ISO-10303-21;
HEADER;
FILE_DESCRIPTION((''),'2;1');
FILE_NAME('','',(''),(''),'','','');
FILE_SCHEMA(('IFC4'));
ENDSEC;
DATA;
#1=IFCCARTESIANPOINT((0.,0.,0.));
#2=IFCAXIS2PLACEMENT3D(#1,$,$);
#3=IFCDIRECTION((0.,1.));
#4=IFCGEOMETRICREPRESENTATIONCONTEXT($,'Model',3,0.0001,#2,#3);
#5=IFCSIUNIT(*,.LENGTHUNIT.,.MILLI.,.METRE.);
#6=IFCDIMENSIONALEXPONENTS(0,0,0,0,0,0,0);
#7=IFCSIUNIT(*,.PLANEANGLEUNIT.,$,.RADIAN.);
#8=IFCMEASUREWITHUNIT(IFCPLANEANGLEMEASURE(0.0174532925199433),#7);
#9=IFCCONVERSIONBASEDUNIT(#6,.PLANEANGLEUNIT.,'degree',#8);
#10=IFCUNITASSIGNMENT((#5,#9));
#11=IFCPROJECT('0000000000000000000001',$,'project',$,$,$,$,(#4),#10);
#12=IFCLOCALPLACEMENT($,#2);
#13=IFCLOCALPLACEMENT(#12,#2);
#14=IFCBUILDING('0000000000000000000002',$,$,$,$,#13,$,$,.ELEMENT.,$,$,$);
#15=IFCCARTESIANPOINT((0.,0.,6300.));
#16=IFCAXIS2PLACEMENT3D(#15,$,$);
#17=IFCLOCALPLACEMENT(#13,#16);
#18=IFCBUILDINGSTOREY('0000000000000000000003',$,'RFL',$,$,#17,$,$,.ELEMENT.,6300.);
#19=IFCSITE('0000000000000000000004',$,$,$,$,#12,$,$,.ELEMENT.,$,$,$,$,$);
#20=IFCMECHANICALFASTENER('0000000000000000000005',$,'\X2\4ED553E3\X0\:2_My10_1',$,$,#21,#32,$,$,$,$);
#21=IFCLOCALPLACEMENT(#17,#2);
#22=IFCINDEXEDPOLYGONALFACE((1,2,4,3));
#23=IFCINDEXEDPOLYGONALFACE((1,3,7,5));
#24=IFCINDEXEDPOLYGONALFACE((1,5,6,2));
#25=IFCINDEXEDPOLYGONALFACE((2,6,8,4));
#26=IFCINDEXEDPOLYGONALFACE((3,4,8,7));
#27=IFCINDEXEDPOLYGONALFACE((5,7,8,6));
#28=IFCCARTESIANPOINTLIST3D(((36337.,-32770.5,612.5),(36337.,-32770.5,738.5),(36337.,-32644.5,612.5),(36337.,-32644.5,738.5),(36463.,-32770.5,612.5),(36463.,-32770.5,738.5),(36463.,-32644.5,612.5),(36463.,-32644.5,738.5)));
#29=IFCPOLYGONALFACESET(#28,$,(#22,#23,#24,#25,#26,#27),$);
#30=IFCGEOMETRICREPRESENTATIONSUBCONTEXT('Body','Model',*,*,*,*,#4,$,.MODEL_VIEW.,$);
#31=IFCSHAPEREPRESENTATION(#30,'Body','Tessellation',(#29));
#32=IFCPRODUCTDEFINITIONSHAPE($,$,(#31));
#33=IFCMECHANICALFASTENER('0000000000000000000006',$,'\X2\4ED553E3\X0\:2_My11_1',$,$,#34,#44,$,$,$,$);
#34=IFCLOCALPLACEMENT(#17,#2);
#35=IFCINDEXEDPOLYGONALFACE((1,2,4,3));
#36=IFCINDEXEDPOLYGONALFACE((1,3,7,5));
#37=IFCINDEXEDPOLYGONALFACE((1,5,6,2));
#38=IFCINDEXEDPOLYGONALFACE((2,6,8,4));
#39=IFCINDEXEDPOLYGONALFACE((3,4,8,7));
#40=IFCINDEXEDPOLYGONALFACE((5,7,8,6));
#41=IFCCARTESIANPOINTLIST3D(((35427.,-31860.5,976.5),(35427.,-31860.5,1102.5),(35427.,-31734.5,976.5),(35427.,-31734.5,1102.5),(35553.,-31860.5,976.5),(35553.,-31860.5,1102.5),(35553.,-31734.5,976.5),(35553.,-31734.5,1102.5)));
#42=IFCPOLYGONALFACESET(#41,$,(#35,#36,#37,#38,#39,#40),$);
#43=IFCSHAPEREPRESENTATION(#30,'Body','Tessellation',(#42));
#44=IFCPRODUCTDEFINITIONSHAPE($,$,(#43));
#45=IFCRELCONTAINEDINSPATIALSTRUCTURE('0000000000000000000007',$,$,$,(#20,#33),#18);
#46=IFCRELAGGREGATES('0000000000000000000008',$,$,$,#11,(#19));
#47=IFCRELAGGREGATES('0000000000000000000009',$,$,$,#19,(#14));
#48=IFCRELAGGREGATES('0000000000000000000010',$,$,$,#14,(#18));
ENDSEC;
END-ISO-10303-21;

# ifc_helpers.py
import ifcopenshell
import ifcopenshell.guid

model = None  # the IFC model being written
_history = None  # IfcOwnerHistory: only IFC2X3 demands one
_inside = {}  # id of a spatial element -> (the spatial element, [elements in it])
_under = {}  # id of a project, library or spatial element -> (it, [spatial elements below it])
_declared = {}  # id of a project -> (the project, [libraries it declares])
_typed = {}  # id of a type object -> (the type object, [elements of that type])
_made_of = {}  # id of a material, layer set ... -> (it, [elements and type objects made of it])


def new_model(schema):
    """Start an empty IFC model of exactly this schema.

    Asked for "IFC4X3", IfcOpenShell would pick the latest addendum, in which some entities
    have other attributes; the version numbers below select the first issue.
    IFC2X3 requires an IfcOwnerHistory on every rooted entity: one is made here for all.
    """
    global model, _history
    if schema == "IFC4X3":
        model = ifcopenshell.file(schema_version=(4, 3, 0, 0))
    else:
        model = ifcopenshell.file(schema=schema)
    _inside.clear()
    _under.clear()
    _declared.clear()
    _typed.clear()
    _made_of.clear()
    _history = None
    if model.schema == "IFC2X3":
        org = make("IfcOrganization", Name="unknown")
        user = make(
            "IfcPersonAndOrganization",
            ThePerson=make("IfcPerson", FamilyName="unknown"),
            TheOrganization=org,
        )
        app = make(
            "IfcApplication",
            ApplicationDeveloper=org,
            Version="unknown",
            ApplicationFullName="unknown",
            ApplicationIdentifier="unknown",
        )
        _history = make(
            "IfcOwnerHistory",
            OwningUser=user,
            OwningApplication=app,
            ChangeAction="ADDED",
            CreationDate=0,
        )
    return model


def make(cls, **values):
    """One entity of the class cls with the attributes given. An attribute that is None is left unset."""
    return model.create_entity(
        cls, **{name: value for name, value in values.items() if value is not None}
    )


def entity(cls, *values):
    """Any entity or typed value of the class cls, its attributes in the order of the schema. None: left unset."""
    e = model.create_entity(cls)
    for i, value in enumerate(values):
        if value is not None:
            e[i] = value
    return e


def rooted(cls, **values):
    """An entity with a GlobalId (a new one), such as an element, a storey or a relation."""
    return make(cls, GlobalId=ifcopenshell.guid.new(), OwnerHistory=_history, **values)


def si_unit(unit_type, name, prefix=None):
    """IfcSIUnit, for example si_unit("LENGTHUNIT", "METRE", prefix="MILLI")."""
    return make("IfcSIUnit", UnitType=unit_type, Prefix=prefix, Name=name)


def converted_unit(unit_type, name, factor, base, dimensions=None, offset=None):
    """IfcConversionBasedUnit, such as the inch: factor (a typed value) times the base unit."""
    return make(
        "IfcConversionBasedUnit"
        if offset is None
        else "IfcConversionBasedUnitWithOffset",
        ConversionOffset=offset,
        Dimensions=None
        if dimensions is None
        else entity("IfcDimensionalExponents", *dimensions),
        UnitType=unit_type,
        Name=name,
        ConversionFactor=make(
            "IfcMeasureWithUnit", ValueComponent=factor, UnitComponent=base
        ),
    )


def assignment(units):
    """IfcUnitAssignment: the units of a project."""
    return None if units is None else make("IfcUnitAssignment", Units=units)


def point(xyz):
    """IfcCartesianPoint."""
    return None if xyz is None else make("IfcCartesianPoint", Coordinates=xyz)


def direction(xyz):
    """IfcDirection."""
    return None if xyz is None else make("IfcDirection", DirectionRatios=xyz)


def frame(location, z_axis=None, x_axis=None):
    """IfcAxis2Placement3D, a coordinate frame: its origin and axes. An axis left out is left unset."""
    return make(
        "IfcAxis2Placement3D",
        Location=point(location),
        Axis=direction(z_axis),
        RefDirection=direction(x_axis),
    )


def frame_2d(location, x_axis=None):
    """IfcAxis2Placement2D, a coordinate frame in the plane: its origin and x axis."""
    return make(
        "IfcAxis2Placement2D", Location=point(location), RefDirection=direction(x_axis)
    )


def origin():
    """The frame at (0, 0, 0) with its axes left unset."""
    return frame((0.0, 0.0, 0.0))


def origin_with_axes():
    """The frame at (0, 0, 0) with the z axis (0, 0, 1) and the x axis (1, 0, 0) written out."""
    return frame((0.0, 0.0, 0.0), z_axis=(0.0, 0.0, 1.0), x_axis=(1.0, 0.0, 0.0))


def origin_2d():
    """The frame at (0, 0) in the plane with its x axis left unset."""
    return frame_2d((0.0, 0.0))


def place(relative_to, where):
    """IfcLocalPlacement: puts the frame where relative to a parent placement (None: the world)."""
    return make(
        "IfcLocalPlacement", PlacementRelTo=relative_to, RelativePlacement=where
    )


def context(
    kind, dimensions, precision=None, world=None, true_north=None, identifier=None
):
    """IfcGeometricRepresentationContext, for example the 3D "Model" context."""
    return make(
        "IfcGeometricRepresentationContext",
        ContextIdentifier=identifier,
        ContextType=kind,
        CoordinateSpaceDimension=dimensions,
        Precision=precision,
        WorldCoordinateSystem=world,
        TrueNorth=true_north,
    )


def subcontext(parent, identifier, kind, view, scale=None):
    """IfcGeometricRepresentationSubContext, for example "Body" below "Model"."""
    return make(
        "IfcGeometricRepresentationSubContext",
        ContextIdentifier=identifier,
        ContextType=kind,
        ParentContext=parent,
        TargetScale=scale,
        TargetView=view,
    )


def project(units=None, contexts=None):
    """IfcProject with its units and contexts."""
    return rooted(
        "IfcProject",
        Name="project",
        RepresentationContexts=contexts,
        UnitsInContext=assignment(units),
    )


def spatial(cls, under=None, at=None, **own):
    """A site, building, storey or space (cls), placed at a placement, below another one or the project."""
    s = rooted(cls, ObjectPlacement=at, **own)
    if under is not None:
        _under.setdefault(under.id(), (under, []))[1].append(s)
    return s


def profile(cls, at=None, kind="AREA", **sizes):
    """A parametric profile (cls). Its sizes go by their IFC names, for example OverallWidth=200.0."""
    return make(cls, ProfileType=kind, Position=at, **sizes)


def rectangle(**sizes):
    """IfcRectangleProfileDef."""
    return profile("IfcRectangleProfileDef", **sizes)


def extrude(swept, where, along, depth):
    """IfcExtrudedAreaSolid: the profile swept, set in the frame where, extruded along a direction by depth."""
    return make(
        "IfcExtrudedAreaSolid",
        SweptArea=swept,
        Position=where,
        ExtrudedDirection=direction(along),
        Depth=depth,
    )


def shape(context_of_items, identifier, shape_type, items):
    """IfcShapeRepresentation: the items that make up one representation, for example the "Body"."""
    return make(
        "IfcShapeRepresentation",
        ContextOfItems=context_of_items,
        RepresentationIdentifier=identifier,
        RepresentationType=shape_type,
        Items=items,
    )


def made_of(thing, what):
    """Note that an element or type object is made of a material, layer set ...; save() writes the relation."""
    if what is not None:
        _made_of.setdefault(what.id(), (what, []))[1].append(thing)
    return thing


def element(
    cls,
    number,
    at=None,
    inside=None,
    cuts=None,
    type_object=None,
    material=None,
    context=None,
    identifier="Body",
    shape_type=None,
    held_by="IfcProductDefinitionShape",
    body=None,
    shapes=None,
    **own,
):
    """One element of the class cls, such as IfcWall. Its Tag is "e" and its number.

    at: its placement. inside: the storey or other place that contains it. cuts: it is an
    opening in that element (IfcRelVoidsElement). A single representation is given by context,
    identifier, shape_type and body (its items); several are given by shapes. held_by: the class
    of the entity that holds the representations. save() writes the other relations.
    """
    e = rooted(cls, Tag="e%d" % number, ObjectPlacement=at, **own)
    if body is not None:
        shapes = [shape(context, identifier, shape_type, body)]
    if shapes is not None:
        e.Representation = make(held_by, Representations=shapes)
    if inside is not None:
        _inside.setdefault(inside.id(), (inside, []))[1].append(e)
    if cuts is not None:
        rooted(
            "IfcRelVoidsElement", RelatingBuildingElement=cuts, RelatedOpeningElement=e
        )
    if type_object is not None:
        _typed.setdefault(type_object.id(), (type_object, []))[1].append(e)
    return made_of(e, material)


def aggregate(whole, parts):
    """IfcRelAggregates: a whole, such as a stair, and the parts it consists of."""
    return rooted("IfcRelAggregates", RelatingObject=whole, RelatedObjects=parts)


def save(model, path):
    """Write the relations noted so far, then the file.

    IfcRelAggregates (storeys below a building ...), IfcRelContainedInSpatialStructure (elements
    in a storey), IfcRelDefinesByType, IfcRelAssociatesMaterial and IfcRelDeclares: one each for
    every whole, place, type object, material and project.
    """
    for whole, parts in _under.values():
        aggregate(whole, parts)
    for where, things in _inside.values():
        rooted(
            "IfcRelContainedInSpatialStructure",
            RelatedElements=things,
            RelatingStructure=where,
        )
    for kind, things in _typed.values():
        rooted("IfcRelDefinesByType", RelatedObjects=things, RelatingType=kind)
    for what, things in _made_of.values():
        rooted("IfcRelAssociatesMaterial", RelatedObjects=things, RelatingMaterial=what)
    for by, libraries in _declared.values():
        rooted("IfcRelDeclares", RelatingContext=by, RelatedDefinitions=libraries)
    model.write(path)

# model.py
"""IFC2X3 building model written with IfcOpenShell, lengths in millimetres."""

from ifc_helpers import new_model, entity, si_unit, converted_unit, direction, frame, origin, origin_with_axes, origin_2d, place, context, subcontext, project, spatial, rectangle, extrude, element, save


model = new_model("IFC2X3")

# Units and contexts
model_context = context("Model", 3, precision=0.0001, world=origin(), true_north=direction((0.0, 1.0)))
body_context = subcontext(model_context, "Body", "Model", "MODEL_VIEW")
ifc_project = project(units=[si_unit("LENGTHUNIT", "METRE", prefix="MILLI"), converted_unit("PLANEANGLEUNIT", "degree", entity("IfcPlaneAngleMeasure", 0.0174532925199433), si_unit("PLANEANGLEUNIT", "RADIAN"), dimensions=[0, 0, 0, 0, 0, 0, 0])], contexts=[model_context])

# Site, building, storey
site_placement = place(None, origin())
site = spatial("IfcSite", under=ifc_project, at=site_placement, CompositionType="ELEMENT")
building_placement = place(site_placement, origin())
building = spatial("IfcBuilding", under=site, at=building_placement, CompositionType="ELEMENT")
storey_placement = place(building_placement, frame((0.0, 0.0, 6300.0)))
storey = spatial("IfcBuildingStorey", under=building, at=storey_placement, Name="RFL", CompositionType="ELEMENT", Elevation=6300.0)

# Mechanical fasteners
for number, where, name in (
    (1, (36400.0, -32707.5, 612.5), "仕口:2_My10_1"),
    (2, (35490.0, -31797.5, 976.5), "仕口:2_My11_1"),
):
    element("IfcMechanicalFastener", number, at=place(storey_placement, frame(where)), inside=storey, Name=name, context=body_context, shape_type="SweptSolid", body=[
        extrude(rectangle(XDim=126.0, YDim=126.0, at=origin_2d()), origin_with_axes(), (0.0, 0.0, 1.0), 126.0),
    ])

save(model, "model.ifc")
